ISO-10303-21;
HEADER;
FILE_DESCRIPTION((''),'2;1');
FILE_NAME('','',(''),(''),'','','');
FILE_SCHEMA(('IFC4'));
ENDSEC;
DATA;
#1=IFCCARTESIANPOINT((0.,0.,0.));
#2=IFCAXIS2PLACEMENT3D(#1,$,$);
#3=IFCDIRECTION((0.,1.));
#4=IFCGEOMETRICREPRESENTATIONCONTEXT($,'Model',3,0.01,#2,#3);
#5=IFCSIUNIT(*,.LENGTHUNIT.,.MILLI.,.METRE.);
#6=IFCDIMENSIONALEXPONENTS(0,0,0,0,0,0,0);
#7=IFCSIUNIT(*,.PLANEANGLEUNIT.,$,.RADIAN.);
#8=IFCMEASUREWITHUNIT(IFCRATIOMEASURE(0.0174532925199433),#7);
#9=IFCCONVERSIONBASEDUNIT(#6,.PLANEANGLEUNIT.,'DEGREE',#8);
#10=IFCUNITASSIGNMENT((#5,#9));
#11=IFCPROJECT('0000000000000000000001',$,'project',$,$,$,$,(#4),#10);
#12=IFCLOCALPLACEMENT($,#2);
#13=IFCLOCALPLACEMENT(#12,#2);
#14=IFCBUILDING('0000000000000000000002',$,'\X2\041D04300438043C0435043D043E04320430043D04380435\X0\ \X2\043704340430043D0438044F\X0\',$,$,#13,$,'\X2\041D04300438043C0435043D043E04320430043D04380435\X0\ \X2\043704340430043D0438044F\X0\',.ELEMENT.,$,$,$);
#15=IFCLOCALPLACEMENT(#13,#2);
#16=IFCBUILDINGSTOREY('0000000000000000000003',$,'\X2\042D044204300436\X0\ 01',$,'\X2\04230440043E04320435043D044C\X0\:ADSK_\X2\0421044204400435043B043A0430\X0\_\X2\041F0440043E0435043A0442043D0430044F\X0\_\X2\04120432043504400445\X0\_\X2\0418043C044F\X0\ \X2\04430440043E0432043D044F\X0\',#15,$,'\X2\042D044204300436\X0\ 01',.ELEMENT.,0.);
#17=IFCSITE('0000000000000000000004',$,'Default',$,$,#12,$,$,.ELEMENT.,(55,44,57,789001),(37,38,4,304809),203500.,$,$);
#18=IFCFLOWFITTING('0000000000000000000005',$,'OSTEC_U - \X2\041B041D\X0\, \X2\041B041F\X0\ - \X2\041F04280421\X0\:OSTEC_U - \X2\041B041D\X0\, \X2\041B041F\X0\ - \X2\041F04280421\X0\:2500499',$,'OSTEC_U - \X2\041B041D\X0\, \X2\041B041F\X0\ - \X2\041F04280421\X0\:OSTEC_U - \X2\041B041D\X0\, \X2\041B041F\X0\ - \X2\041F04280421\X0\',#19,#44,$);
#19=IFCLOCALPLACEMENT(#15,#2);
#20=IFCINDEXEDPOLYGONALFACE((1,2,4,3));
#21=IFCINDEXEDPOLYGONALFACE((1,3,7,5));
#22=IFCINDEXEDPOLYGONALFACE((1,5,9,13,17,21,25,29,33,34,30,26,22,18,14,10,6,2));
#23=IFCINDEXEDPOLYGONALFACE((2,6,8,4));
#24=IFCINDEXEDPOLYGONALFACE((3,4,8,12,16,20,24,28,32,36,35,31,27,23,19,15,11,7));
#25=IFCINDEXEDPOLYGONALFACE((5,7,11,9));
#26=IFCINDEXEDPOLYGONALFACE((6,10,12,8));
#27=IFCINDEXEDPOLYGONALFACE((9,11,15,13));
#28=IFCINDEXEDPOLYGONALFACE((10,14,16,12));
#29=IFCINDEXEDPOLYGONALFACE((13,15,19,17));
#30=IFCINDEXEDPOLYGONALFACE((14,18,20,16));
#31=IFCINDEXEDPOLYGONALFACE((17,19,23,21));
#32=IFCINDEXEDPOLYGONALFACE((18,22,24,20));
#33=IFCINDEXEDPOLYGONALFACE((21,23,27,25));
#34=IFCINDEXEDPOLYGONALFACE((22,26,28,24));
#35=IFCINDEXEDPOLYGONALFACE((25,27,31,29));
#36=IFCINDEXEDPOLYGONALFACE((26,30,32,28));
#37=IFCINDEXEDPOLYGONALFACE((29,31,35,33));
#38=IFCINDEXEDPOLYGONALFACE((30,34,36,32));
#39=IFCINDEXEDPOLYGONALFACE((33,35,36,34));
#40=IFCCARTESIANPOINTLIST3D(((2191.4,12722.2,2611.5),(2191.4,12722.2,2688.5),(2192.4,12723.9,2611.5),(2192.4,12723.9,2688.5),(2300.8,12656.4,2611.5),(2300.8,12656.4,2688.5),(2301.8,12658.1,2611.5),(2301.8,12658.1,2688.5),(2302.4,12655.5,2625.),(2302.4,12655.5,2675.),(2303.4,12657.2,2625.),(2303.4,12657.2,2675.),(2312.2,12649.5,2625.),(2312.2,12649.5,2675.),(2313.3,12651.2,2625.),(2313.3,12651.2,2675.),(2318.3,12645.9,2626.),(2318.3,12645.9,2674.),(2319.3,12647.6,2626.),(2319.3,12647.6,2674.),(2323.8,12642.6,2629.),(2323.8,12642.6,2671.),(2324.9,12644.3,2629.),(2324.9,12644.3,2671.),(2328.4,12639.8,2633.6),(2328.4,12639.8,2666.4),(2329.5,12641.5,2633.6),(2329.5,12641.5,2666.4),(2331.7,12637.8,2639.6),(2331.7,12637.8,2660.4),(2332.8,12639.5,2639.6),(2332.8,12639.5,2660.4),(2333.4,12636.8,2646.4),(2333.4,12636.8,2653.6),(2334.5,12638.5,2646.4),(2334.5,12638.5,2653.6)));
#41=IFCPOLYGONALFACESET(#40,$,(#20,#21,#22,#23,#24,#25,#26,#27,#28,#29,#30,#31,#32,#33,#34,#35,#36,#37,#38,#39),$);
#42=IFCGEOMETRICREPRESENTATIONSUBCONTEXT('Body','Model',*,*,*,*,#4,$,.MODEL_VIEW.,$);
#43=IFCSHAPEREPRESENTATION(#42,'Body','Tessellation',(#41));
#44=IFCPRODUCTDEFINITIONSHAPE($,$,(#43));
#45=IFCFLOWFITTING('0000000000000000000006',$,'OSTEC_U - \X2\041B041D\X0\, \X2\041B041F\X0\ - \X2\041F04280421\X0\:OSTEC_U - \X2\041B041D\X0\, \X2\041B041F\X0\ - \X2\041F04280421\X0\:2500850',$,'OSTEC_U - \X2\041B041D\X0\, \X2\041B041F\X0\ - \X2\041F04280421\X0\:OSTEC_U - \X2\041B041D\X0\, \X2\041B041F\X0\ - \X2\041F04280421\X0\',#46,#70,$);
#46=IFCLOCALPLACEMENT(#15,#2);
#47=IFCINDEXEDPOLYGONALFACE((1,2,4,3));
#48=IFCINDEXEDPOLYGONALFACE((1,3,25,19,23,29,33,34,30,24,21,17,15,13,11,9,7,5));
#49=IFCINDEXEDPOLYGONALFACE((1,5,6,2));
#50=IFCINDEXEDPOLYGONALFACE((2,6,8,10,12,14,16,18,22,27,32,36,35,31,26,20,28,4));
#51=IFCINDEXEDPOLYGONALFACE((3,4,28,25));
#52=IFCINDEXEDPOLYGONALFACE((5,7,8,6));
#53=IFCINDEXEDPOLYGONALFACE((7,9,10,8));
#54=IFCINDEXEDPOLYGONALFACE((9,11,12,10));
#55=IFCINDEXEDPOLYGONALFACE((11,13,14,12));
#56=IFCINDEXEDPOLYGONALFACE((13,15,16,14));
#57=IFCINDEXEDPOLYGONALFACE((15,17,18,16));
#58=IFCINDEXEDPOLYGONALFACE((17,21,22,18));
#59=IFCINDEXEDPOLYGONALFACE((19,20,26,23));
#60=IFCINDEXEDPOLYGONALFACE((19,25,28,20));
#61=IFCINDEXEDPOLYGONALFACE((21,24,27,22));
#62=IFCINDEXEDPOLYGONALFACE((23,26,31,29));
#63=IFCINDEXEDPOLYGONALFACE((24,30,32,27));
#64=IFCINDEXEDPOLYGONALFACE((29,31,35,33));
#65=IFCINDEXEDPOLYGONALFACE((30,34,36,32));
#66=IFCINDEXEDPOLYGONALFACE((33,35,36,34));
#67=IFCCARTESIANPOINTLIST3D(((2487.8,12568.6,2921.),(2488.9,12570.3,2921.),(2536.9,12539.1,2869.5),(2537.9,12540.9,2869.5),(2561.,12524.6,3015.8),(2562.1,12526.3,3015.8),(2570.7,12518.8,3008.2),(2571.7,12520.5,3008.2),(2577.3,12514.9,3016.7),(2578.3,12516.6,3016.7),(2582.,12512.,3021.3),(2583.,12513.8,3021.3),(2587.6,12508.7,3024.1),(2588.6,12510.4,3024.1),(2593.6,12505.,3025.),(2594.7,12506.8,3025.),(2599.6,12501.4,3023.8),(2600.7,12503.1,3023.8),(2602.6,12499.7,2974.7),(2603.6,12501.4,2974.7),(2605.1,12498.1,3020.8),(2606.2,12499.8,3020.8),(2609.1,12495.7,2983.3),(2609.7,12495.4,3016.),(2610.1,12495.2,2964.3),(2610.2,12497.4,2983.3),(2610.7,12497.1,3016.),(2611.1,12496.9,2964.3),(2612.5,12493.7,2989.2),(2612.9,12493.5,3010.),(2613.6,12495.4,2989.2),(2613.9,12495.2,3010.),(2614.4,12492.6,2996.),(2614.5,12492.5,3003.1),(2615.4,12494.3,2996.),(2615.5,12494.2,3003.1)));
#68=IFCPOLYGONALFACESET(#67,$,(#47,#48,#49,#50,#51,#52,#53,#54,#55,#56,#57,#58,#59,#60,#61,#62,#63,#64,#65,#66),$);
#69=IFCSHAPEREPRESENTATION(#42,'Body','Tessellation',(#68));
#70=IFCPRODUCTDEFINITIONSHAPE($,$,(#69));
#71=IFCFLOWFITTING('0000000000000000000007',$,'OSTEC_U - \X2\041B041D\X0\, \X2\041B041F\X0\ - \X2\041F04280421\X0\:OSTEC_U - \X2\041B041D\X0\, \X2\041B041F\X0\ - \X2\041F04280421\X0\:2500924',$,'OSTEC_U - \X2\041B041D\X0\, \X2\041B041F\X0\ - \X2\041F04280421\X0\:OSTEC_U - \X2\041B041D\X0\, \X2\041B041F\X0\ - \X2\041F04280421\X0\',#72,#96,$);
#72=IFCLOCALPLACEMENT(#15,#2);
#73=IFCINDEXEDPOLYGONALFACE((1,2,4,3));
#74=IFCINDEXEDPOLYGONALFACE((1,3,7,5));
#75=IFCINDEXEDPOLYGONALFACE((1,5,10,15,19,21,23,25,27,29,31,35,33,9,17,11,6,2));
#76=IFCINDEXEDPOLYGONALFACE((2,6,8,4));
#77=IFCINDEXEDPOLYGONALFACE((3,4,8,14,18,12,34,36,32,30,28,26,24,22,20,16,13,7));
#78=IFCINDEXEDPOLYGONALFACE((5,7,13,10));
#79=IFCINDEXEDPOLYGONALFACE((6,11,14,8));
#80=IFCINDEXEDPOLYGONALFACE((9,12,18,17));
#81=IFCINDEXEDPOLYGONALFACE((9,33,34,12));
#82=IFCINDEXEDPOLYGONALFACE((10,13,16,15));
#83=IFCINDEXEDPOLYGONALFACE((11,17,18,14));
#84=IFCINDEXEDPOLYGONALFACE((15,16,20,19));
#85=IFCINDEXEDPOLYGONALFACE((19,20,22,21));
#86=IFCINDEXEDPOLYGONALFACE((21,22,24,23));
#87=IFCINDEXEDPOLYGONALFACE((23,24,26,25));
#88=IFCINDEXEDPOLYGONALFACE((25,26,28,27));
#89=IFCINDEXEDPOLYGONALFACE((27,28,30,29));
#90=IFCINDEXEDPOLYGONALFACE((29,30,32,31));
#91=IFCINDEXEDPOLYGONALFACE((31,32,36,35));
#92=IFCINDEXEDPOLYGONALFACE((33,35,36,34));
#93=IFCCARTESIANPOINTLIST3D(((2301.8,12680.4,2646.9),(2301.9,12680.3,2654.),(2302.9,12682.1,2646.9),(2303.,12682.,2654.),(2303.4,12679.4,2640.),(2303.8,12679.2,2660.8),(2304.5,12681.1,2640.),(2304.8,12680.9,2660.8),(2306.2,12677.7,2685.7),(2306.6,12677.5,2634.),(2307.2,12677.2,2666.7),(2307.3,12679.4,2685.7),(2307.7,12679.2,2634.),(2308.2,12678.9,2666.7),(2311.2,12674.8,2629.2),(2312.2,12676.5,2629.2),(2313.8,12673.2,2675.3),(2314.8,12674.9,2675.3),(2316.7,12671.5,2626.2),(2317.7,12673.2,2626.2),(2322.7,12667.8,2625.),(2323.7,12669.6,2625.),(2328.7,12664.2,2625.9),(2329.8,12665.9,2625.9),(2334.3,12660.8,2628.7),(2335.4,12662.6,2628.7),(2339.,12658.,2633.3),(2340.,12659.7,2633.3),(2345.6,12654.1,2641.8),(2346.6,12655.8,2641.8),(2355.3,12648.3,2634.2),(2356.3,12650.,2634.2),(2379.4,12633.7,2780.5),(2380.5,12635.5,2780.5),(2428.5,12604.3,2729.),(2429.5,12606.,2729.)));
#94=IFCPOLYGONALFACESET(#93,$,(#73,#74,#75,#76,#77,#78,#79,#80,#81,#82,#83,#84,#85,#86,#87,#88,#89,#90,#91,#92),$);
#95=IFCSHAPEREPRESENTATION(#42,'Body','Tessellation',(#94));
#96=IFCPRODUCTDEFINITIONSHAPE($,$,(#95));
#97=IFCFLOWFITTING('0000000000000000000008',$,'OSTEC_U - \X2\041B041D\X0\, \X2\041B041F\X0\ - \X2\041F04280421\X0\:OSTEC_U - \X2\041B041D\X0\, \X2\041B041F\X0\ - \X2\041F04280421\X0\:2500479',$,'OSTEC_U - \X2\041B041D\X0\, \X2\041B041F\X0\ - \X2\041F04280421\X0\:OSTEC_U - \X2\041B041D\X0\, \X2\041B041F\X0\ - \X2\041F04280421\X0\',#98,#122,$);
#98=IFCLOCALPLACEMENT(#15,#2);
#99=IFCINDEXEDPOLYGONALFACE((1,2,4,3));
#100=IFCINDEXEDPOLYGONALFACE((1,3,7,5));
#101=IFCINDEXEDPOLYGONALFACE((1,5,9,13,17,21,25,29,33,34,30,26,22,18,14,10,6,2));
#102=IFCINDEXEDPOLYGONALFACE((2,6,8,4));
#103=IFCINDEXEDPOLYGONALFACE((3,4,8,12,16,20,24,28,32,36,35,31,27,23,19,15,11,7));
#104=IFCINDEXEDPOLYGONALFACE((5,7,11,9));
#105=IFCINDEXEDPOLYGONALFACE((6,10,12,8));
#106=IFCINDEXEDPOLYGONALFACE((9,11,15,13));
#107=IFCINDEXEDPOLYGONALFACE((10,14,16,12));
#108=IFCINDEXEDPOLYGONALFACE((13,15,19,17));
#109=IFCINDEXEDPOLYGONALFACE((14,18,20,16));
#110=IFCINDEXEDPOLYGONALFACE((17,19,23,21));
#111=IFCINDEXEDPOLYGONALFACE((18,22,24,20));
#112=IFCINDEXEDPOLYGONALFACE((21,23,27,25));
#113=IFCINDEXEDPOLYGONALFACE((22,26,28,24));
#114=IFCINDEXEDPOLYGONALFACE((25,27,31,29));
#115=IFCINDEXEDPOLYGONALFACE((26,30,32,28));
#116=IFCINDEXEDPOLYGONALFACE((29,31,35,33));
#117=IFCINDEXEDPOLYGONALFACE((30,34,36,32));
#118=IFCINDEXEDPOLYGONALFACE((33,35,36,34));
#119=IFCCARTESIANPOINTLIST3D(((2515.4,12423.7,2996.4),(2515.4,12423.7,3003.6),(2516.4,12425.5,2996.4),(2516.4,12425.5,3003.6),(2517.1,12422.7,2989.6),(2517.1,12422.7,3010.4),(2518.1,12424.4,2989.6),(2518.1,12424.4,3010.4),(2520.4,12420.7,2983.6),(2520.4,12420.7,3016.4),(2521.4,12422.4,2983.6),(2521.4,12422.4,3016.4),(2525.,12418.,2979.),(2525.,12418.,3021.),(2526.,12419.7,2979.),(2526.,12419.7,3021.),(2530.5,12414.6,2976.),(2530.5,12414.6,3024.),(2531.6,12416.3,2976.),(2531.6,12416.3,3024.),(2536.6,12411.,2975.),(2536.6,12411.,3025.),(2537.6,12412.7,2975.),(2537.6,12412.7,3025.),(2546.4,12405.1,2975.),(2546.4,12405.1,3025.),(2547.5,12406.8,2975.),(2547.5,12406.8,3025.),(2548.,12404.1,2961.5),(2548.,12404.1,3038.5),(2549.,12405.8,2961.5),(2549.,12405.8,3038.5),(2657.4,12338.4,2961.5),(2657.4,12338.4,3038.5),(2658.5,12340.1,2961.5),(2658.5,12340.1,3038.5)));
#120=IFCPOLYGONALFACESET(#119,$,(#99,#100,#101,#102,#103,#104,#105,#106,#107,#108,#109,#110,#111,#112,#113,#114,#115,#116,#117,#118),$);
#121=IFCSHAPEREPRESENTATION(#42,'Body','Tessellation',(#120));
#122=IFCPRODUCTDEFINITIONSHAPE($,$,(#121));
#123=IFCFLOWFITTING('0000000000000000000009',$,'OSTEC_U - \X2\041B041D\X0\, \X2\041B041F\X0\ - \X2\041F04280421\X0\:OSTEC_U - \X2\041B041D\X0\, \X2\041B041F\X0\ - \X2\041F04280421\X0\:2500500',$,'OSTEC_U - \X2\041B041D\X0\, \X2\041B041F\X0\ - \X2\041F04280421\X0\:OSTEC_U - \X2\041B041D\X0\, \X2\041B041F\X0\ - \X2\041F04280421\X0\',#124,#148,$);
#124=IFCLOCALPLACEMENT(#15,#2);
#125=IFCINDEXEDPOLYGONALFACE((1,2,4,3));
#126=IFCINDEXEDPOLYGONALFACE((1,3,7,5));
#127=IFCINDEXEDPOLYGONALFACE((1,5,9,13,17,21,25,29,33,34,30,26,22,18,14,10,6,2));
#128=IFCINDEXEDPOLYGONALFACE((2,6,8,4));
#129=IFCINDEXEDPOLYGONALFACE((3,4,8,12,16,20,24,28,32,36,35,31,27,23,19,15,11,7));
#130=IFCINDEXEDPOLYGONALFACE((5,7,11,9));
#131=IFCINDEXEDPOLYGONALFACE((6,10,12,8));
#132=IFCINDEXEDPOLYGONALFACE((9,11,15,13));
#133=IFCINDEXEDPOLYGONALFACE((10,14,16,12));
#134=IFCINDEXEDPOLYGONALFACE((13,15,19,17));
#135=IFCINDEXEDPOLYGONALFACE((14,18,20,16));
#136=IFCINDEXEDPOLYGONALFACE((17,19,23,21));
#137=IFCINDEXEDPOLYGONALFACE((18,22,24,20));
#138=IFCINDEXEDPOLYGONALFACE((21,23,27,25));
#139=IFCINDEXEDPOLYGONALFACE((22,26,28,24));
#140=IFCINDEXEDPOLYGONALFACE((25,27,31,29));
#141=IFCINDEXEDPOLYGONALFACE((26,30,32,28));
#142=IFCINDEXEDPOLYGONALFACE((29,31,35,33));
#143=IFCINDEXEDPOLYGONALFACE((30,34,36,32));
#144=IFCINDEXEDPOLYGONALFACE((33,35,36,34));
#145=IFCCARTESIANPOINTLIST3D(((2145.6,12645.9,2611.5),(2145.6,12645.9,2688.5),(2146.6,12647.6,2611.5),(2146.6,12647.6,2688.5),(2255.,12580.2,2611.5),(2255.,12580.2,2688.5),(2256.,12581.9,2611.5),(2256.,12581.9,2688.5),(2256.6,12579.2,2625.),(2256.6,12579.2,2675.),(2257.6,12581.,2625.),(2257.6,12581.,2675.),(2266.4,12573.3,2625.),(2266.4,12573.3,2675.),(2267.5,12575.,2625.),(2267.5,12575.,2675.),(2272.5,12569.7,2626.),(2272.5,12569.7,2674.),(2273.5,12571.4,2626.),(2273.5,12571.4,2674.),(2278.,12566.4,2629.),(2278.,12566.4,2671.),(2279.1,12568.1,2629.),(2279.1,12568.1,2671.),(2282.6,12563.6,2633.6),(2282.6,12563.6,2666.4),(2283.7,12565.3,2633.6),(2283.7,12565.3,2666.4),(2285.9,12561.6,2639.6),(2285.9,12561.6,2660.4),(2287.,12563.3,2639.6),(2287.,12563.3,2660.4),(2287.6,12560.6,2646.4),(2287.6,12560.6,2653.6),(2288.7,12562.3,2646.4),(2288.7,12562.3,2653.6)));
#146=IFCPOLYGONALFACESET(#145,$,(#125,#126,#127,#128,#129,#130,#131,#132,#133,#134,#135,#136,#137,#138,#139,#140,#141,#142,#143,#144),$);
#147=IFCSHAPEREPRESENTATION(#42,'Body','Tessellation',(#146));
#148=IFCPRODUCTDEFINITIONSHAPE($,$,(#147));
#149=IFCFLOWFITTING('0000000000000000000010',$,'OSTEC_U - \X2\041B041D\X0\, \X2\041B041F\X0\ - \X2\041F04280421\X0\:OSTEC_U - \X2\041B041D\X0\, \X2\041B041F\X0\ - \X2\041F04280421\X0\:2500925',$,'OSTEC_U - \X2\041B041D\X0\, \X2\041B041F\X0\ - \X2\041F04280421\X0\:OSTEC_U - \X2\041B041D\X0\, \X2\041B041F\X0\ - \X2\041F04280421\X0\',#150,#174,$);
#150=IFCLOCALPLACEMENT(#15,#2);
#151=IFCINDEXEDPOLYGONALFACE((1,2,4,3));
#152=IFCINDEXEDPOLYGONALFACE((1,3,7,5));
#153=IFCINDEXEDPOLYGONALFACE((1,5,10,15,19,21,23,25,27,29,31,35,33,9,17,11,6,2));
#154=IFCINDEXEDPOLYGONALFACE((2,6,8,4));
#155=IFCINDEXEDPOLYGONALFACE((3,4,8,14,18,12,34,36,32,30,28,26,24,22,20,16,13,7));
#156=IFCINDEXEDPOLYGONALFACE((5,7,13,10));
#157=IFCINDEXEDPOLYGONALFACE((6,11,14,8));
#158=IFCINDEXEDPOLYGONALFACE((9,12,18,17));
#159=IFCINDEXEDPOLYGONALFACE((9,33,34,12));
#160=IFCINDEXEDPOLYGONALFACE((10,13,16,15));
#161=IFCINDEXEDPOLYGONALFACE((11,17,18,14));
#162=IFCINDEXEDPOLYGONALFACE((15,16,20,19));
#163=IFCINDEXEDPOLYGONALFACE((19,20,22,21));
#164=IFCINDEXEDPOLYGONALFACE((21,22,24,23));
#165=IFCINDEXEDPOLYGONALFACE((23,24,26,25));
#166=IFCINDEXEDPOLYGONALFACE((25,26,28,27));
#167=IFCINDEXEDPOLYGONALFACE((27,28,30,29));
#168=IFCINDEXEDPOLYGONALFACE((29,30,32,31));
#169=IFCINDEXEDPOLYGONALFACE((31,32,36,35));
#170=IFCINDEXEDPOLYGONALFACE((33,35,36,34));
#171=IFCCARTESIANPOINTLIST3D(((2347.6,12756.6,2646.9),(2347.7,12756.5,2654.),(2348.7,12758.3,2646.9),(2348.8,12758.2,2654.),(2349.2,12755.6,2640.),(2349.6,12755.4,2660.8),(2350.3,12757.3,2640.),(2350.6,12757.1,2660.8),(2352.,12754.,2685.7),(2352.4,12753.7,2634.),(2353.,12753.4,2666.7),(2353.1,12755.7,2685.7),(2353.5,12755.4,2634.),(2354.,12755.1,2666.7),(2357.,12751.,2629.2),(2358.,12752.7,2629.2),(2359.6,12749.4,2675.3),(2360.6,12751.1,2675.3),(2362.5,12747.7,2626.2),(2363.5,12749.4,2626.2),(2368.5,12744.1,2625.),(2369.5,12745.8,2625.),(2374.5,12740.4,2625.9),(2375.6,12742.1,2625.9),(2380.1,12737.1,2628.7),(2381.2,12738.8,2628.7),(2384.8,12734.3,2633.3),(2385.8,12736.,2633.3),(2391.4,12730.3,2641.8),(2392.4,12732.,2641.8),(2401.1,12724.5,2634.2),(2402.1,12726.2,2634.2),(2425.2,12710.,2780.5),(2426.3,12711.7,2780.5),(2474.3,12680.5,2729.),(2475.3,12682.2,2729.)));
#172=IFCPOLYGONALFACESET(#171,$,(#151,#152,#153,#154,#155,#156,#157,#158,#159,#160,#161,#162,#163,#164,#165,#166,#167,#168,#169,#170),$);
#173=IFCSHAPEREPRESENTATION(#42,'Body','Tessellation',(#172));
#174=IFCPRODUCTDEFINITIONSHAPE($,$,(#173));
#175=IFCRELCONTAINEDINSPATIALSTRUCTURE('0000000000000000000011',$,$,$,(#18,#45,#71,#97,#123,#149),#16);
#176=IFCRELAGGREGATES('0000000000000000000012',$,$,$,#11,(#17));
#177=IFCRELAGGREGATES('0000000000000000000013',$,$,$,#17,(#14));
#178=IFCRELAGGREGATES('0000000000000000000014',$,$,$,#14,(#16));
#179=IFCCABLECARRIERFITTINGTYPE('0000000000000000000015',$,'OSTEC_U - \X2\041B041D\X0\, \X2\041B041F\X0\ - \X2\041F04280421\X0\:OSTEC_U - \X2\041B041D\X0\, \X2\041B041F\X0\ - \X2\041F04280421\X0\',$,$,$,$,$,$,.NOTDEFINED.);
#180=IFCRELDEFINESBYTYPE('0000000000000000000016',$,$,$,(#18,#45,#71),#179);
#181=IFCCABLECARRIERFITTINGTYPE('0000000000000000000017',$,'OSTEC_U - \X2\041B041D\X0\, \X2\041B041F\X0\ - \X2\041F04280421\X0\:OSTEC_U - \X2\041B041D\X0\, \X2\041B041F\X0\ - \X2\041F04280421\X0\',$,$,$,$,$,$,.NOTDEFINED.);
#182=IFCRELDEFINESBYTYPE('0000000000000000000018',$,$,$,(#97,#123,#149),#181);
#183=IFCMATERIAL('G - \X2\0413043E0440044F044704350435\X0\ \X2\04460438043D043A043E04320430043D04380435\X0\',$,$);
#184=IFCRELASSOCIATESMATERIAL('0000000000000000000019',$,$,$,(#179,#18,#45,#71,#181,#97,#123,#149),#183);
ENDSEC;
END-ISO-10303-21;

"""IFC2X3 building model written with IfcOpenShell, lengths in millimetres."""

from ifc_helpers import new_model, entity, si_unit, converted_unit, direction, frame, frame_2d, origin, place, context, subcontext, project, spatial, polyline, circle_curve, parameter, trimmed, segment, composite_curve, outline, extrude, source, transform, mapped, material, type_object, type_shapes, element, save


model = new_model("IFC2X3")

# Units and contexts
model_context = context("Model", 3, precision=0.01, world=origin(), true_north=direction((0.0, 1.0)))
body_context = subcontext(model_context, "Body", "Model", "MODEL_VIEW")
ifc_project = project(units=[si_unit("LENGTHUNIT", "METRE", prefix="MILLI"), converted_unit("PLANEANGLEUNIT", "DEGREE", entity("IfcRatioMeasure", 0.0174532925199433), si_unit("PLANEANGLEUNIT", "RADIAN"), dimensions=[0, 0, 0, 0, 0, 0, 0])], contexts=[model_context])

# Site, building, storey
site_placement = place(None, frame((0.0, 0.0, 0.0)))
site = spatial("IfcSite", under=ifc_project, at=site_placement, Name="Default", CompositionType="ELEMENT", RefLatitude=(55, 44, 57, 789001), RefLongitude=(37, 38, 4, 304809), RefElevation=203500.0)
building_placement = place(site_placement, origin())
building = spatial("IfcBuilding", under=site, at=building_placement, Name="Наименование здания", LongName="Наименование здания", CompositionType="ELEMENT")
storey_placement = place(building_placement, origin())
storey = spatial("IfcBuildingStorey", under=building, at=storey_placement, Name="Этаж 01", ObjectType="Уровень:ADSK_Стрелка_Проектная_Вверх_Имя уровня", LongName="Этаж 01", CompositionType="ELEMENT", Elevation=0.0)

# Flow fittings
ifc_material_1 = material(Name="G - Горячее цинкование")
cable_carrier_fitting_type_1 = type_object("IfcCableCarrierFittingType", Name="OSTEC_U - ЛН, ЛП - ПШС:OSTEC_U - ЛН, ЛП - ПШС", PredefinedType="NOTDEFINED", material=ifc_material_1)
shared_shape_1 = source(origin(), body_context, "Body", "SweptSolid", [
    extrude(outline(composite_curve([segment(trimmed(circle_curve(frame_2d((-41.5, 0.0), x_axis=(1.0, 0.0)), 25.0), [parameter(90.0)], [parameter(270.0)], True, "PARAMETER"), True, "CONTINUOUS"), segment(polyline([(-41.5, -25.0), (-30.0, -25.0)]), True, "CONTINUOUS"), segment(polyline([(-30.0, -25.0), (-28.1, -38.5)]), True, "CONTINUOUS"), segment(polyline([(-28.1, -38.5), (99.5, -38.5)]), True, "CONTINUOUS"), segment(polyline([(99.5, -38.5), (99.5, 38.5)]), True, "CONTINUOUS"), segment(polyline([(99.5, 38.5), (-28.1, 38.5)]), True, "CONTINUOUS"), segment(polyline([(-28.1, 38.5), (-30.0, 25.0)]), True, "CONTINUOUS"), segment(polyline([(-30.0, 25.0), (-41.5, 25.0)]), True, "CONTINUOUS")], self_intersect=False)), frame((41.5, 0.0, 0.0), z_axis=(0.0, 0.0, -1.0), x_axis=(1.0, 0.0, 0.0)), (0.0, 0.0, -1.0), 2.0),
])
type_shapes(cable_carrier_fitting_type_1, [shared_shape_1])
for number, where, z_axis, x_axis, name in (
    (1, (2312.2, 12649.5, 2650.0), (0.515038, 0.857167, 0.0), (-0.857167, 0.515038, 0.0), "OSTEC_U - ЛН, ЛП - ПШС:OSTEC_U - ЛН, ЛП - ПШС:2500499"),
    (2, (2594.3, 12507.0, 3000.0), (-0.515038, -0.857167, 0.0), (-0.573557, 0.344628, -0.743145), "OSTEC_U - ЛН, ЛП - ПШС:OSTEC_U - ЛН, ЛП - ПШС:2500850"),
    (3, (2324.1, 12669.3, 2650.0), (-0.515038, -0.857167, 0.0), (0.573557, -0.344628, 0.743145), "OSTEC_U - ЛН, ЛП - ПШС:OSTEC_U - ЛН, ЛП - ПШС:2500924"),
):
    element("IfcFlowFitting", number, at=place(storey_placement, frame(where, z_axis=z_axis, x_axis=x_axis)), inside=storey, type_object=cable_carrier_fitting_type_1, material=ifc_material_1, Name=name, ObjectType="OSTEC_U - ЛН, ЛП - ПШС:OSTEC_U - ЛН, ЛП - ПШС", context=body_context, shape_type="MappedRepresentation", body=[
        mapped(shared_shape_1, transform((0.0, 0.0, 0.0), scale=1.0)),
    ])
cable_carrier_fitting_type_2 = type_object("IfcCableCarrierFittingType", Name="OSTEC_U - ЛН, ЛП - ПШС:OSTEC_U - ЛН, ЛП - ПШС", PredefinedType="NOTDEFINED", material=ifc_material_1)
shared_shape_2 = source(origin(), body_context, "Body", "SweptSolid", [
    extrude(outline(composite_curve([segment(trimmed(circle_curve(frame_2d((-41.5, 0.0), x_axis=(1.0, 0.0)), 25.0), [parameter(90.0)], [parameter(270.0)], True, "PARAMETER"), True, "CONTINUOUS"), segment(polyline([(-41.5, -25.0), (-30.0, -25.0)]), True, "CONTINUOUS"), segment(polyline([(-30.0, -25.0), (-28.1, -38.5)]), True, "CONTINUOUS"), segment(polyline([(-28.1, -38.5), (99.5, -38.5)]), True, "CONTINUOUS"), segment(polyline([(99.5, -38.5), (99.5, 38.5)]), True, "CONTINUOUS"), segment(polyline([(99.5, 38.5), (-28.1, 38.5)]), True, "CONTINUOUS"), segment(polyline([(-28.1, 38.5), (-30.0, 25.0)]), True, "CONTINUOUS"), segment(polyline([(-30.0, 25.0), (-41.5, 25.0)]), True, "CONTINUOUS")], self_intersect=False)), frame((41.5, 0.0, 0.0)), (0.0, 0.0, 1.0), 2.0),
])
type_shapes(cable_carrier_fitting_type_2, [shared_shape_2])
for number, where, z_axis, x_axis, name in (
    (4, (2537.6, 12412.7, 3000.0), (-0.515038, -0.857167, 0.0), (0.857167, -0.515038, 0.0), "OSTEC_U - ЛН, ЛП - ПШС:OSTEC_U - ЛН, ЛП - ПШС:2500479"),
    (5, (2267.5, 12575.0, 2650.0), (-0.515038, -0.857167, 0.0), (-0.857167, 0.515038, 0.0), "OSTEC_U - ЛН, ЛП - ПШС:OSTEC_U - ЛН, ЛП - ПШС:2500500"),
    (6, (2368.9, 12743.8, 2650.0), (0.515038, 0.857167, 0.0), (0.573557, -0.344628, 0.743145), "OSTEC_U - ЛН, ЛП - ПШС:OSTEC_U - ЛН, ЛП - ПШС:2500925"),
):
    element("IfcFlowFitting", number, at=place(storey_placement, frame(where, z_axis=z_axis, x_axis=x_axis)), inside=storey, type_object=cable_carrier_fitting_type_2, material=ifc_material_1, Name=name, ObjectType="OSTEC_U - ЛН, ЛП - ПШС:OSTEC_U - ЛН, ЛП - ПШС", context=body_context, shape_type="MappedRepresentation", body=[
        mapped(shared_shape_2, transform((0.0, 0.0, 0.0), scale=1.0)),
    ])

save(model, "model.ifc")
